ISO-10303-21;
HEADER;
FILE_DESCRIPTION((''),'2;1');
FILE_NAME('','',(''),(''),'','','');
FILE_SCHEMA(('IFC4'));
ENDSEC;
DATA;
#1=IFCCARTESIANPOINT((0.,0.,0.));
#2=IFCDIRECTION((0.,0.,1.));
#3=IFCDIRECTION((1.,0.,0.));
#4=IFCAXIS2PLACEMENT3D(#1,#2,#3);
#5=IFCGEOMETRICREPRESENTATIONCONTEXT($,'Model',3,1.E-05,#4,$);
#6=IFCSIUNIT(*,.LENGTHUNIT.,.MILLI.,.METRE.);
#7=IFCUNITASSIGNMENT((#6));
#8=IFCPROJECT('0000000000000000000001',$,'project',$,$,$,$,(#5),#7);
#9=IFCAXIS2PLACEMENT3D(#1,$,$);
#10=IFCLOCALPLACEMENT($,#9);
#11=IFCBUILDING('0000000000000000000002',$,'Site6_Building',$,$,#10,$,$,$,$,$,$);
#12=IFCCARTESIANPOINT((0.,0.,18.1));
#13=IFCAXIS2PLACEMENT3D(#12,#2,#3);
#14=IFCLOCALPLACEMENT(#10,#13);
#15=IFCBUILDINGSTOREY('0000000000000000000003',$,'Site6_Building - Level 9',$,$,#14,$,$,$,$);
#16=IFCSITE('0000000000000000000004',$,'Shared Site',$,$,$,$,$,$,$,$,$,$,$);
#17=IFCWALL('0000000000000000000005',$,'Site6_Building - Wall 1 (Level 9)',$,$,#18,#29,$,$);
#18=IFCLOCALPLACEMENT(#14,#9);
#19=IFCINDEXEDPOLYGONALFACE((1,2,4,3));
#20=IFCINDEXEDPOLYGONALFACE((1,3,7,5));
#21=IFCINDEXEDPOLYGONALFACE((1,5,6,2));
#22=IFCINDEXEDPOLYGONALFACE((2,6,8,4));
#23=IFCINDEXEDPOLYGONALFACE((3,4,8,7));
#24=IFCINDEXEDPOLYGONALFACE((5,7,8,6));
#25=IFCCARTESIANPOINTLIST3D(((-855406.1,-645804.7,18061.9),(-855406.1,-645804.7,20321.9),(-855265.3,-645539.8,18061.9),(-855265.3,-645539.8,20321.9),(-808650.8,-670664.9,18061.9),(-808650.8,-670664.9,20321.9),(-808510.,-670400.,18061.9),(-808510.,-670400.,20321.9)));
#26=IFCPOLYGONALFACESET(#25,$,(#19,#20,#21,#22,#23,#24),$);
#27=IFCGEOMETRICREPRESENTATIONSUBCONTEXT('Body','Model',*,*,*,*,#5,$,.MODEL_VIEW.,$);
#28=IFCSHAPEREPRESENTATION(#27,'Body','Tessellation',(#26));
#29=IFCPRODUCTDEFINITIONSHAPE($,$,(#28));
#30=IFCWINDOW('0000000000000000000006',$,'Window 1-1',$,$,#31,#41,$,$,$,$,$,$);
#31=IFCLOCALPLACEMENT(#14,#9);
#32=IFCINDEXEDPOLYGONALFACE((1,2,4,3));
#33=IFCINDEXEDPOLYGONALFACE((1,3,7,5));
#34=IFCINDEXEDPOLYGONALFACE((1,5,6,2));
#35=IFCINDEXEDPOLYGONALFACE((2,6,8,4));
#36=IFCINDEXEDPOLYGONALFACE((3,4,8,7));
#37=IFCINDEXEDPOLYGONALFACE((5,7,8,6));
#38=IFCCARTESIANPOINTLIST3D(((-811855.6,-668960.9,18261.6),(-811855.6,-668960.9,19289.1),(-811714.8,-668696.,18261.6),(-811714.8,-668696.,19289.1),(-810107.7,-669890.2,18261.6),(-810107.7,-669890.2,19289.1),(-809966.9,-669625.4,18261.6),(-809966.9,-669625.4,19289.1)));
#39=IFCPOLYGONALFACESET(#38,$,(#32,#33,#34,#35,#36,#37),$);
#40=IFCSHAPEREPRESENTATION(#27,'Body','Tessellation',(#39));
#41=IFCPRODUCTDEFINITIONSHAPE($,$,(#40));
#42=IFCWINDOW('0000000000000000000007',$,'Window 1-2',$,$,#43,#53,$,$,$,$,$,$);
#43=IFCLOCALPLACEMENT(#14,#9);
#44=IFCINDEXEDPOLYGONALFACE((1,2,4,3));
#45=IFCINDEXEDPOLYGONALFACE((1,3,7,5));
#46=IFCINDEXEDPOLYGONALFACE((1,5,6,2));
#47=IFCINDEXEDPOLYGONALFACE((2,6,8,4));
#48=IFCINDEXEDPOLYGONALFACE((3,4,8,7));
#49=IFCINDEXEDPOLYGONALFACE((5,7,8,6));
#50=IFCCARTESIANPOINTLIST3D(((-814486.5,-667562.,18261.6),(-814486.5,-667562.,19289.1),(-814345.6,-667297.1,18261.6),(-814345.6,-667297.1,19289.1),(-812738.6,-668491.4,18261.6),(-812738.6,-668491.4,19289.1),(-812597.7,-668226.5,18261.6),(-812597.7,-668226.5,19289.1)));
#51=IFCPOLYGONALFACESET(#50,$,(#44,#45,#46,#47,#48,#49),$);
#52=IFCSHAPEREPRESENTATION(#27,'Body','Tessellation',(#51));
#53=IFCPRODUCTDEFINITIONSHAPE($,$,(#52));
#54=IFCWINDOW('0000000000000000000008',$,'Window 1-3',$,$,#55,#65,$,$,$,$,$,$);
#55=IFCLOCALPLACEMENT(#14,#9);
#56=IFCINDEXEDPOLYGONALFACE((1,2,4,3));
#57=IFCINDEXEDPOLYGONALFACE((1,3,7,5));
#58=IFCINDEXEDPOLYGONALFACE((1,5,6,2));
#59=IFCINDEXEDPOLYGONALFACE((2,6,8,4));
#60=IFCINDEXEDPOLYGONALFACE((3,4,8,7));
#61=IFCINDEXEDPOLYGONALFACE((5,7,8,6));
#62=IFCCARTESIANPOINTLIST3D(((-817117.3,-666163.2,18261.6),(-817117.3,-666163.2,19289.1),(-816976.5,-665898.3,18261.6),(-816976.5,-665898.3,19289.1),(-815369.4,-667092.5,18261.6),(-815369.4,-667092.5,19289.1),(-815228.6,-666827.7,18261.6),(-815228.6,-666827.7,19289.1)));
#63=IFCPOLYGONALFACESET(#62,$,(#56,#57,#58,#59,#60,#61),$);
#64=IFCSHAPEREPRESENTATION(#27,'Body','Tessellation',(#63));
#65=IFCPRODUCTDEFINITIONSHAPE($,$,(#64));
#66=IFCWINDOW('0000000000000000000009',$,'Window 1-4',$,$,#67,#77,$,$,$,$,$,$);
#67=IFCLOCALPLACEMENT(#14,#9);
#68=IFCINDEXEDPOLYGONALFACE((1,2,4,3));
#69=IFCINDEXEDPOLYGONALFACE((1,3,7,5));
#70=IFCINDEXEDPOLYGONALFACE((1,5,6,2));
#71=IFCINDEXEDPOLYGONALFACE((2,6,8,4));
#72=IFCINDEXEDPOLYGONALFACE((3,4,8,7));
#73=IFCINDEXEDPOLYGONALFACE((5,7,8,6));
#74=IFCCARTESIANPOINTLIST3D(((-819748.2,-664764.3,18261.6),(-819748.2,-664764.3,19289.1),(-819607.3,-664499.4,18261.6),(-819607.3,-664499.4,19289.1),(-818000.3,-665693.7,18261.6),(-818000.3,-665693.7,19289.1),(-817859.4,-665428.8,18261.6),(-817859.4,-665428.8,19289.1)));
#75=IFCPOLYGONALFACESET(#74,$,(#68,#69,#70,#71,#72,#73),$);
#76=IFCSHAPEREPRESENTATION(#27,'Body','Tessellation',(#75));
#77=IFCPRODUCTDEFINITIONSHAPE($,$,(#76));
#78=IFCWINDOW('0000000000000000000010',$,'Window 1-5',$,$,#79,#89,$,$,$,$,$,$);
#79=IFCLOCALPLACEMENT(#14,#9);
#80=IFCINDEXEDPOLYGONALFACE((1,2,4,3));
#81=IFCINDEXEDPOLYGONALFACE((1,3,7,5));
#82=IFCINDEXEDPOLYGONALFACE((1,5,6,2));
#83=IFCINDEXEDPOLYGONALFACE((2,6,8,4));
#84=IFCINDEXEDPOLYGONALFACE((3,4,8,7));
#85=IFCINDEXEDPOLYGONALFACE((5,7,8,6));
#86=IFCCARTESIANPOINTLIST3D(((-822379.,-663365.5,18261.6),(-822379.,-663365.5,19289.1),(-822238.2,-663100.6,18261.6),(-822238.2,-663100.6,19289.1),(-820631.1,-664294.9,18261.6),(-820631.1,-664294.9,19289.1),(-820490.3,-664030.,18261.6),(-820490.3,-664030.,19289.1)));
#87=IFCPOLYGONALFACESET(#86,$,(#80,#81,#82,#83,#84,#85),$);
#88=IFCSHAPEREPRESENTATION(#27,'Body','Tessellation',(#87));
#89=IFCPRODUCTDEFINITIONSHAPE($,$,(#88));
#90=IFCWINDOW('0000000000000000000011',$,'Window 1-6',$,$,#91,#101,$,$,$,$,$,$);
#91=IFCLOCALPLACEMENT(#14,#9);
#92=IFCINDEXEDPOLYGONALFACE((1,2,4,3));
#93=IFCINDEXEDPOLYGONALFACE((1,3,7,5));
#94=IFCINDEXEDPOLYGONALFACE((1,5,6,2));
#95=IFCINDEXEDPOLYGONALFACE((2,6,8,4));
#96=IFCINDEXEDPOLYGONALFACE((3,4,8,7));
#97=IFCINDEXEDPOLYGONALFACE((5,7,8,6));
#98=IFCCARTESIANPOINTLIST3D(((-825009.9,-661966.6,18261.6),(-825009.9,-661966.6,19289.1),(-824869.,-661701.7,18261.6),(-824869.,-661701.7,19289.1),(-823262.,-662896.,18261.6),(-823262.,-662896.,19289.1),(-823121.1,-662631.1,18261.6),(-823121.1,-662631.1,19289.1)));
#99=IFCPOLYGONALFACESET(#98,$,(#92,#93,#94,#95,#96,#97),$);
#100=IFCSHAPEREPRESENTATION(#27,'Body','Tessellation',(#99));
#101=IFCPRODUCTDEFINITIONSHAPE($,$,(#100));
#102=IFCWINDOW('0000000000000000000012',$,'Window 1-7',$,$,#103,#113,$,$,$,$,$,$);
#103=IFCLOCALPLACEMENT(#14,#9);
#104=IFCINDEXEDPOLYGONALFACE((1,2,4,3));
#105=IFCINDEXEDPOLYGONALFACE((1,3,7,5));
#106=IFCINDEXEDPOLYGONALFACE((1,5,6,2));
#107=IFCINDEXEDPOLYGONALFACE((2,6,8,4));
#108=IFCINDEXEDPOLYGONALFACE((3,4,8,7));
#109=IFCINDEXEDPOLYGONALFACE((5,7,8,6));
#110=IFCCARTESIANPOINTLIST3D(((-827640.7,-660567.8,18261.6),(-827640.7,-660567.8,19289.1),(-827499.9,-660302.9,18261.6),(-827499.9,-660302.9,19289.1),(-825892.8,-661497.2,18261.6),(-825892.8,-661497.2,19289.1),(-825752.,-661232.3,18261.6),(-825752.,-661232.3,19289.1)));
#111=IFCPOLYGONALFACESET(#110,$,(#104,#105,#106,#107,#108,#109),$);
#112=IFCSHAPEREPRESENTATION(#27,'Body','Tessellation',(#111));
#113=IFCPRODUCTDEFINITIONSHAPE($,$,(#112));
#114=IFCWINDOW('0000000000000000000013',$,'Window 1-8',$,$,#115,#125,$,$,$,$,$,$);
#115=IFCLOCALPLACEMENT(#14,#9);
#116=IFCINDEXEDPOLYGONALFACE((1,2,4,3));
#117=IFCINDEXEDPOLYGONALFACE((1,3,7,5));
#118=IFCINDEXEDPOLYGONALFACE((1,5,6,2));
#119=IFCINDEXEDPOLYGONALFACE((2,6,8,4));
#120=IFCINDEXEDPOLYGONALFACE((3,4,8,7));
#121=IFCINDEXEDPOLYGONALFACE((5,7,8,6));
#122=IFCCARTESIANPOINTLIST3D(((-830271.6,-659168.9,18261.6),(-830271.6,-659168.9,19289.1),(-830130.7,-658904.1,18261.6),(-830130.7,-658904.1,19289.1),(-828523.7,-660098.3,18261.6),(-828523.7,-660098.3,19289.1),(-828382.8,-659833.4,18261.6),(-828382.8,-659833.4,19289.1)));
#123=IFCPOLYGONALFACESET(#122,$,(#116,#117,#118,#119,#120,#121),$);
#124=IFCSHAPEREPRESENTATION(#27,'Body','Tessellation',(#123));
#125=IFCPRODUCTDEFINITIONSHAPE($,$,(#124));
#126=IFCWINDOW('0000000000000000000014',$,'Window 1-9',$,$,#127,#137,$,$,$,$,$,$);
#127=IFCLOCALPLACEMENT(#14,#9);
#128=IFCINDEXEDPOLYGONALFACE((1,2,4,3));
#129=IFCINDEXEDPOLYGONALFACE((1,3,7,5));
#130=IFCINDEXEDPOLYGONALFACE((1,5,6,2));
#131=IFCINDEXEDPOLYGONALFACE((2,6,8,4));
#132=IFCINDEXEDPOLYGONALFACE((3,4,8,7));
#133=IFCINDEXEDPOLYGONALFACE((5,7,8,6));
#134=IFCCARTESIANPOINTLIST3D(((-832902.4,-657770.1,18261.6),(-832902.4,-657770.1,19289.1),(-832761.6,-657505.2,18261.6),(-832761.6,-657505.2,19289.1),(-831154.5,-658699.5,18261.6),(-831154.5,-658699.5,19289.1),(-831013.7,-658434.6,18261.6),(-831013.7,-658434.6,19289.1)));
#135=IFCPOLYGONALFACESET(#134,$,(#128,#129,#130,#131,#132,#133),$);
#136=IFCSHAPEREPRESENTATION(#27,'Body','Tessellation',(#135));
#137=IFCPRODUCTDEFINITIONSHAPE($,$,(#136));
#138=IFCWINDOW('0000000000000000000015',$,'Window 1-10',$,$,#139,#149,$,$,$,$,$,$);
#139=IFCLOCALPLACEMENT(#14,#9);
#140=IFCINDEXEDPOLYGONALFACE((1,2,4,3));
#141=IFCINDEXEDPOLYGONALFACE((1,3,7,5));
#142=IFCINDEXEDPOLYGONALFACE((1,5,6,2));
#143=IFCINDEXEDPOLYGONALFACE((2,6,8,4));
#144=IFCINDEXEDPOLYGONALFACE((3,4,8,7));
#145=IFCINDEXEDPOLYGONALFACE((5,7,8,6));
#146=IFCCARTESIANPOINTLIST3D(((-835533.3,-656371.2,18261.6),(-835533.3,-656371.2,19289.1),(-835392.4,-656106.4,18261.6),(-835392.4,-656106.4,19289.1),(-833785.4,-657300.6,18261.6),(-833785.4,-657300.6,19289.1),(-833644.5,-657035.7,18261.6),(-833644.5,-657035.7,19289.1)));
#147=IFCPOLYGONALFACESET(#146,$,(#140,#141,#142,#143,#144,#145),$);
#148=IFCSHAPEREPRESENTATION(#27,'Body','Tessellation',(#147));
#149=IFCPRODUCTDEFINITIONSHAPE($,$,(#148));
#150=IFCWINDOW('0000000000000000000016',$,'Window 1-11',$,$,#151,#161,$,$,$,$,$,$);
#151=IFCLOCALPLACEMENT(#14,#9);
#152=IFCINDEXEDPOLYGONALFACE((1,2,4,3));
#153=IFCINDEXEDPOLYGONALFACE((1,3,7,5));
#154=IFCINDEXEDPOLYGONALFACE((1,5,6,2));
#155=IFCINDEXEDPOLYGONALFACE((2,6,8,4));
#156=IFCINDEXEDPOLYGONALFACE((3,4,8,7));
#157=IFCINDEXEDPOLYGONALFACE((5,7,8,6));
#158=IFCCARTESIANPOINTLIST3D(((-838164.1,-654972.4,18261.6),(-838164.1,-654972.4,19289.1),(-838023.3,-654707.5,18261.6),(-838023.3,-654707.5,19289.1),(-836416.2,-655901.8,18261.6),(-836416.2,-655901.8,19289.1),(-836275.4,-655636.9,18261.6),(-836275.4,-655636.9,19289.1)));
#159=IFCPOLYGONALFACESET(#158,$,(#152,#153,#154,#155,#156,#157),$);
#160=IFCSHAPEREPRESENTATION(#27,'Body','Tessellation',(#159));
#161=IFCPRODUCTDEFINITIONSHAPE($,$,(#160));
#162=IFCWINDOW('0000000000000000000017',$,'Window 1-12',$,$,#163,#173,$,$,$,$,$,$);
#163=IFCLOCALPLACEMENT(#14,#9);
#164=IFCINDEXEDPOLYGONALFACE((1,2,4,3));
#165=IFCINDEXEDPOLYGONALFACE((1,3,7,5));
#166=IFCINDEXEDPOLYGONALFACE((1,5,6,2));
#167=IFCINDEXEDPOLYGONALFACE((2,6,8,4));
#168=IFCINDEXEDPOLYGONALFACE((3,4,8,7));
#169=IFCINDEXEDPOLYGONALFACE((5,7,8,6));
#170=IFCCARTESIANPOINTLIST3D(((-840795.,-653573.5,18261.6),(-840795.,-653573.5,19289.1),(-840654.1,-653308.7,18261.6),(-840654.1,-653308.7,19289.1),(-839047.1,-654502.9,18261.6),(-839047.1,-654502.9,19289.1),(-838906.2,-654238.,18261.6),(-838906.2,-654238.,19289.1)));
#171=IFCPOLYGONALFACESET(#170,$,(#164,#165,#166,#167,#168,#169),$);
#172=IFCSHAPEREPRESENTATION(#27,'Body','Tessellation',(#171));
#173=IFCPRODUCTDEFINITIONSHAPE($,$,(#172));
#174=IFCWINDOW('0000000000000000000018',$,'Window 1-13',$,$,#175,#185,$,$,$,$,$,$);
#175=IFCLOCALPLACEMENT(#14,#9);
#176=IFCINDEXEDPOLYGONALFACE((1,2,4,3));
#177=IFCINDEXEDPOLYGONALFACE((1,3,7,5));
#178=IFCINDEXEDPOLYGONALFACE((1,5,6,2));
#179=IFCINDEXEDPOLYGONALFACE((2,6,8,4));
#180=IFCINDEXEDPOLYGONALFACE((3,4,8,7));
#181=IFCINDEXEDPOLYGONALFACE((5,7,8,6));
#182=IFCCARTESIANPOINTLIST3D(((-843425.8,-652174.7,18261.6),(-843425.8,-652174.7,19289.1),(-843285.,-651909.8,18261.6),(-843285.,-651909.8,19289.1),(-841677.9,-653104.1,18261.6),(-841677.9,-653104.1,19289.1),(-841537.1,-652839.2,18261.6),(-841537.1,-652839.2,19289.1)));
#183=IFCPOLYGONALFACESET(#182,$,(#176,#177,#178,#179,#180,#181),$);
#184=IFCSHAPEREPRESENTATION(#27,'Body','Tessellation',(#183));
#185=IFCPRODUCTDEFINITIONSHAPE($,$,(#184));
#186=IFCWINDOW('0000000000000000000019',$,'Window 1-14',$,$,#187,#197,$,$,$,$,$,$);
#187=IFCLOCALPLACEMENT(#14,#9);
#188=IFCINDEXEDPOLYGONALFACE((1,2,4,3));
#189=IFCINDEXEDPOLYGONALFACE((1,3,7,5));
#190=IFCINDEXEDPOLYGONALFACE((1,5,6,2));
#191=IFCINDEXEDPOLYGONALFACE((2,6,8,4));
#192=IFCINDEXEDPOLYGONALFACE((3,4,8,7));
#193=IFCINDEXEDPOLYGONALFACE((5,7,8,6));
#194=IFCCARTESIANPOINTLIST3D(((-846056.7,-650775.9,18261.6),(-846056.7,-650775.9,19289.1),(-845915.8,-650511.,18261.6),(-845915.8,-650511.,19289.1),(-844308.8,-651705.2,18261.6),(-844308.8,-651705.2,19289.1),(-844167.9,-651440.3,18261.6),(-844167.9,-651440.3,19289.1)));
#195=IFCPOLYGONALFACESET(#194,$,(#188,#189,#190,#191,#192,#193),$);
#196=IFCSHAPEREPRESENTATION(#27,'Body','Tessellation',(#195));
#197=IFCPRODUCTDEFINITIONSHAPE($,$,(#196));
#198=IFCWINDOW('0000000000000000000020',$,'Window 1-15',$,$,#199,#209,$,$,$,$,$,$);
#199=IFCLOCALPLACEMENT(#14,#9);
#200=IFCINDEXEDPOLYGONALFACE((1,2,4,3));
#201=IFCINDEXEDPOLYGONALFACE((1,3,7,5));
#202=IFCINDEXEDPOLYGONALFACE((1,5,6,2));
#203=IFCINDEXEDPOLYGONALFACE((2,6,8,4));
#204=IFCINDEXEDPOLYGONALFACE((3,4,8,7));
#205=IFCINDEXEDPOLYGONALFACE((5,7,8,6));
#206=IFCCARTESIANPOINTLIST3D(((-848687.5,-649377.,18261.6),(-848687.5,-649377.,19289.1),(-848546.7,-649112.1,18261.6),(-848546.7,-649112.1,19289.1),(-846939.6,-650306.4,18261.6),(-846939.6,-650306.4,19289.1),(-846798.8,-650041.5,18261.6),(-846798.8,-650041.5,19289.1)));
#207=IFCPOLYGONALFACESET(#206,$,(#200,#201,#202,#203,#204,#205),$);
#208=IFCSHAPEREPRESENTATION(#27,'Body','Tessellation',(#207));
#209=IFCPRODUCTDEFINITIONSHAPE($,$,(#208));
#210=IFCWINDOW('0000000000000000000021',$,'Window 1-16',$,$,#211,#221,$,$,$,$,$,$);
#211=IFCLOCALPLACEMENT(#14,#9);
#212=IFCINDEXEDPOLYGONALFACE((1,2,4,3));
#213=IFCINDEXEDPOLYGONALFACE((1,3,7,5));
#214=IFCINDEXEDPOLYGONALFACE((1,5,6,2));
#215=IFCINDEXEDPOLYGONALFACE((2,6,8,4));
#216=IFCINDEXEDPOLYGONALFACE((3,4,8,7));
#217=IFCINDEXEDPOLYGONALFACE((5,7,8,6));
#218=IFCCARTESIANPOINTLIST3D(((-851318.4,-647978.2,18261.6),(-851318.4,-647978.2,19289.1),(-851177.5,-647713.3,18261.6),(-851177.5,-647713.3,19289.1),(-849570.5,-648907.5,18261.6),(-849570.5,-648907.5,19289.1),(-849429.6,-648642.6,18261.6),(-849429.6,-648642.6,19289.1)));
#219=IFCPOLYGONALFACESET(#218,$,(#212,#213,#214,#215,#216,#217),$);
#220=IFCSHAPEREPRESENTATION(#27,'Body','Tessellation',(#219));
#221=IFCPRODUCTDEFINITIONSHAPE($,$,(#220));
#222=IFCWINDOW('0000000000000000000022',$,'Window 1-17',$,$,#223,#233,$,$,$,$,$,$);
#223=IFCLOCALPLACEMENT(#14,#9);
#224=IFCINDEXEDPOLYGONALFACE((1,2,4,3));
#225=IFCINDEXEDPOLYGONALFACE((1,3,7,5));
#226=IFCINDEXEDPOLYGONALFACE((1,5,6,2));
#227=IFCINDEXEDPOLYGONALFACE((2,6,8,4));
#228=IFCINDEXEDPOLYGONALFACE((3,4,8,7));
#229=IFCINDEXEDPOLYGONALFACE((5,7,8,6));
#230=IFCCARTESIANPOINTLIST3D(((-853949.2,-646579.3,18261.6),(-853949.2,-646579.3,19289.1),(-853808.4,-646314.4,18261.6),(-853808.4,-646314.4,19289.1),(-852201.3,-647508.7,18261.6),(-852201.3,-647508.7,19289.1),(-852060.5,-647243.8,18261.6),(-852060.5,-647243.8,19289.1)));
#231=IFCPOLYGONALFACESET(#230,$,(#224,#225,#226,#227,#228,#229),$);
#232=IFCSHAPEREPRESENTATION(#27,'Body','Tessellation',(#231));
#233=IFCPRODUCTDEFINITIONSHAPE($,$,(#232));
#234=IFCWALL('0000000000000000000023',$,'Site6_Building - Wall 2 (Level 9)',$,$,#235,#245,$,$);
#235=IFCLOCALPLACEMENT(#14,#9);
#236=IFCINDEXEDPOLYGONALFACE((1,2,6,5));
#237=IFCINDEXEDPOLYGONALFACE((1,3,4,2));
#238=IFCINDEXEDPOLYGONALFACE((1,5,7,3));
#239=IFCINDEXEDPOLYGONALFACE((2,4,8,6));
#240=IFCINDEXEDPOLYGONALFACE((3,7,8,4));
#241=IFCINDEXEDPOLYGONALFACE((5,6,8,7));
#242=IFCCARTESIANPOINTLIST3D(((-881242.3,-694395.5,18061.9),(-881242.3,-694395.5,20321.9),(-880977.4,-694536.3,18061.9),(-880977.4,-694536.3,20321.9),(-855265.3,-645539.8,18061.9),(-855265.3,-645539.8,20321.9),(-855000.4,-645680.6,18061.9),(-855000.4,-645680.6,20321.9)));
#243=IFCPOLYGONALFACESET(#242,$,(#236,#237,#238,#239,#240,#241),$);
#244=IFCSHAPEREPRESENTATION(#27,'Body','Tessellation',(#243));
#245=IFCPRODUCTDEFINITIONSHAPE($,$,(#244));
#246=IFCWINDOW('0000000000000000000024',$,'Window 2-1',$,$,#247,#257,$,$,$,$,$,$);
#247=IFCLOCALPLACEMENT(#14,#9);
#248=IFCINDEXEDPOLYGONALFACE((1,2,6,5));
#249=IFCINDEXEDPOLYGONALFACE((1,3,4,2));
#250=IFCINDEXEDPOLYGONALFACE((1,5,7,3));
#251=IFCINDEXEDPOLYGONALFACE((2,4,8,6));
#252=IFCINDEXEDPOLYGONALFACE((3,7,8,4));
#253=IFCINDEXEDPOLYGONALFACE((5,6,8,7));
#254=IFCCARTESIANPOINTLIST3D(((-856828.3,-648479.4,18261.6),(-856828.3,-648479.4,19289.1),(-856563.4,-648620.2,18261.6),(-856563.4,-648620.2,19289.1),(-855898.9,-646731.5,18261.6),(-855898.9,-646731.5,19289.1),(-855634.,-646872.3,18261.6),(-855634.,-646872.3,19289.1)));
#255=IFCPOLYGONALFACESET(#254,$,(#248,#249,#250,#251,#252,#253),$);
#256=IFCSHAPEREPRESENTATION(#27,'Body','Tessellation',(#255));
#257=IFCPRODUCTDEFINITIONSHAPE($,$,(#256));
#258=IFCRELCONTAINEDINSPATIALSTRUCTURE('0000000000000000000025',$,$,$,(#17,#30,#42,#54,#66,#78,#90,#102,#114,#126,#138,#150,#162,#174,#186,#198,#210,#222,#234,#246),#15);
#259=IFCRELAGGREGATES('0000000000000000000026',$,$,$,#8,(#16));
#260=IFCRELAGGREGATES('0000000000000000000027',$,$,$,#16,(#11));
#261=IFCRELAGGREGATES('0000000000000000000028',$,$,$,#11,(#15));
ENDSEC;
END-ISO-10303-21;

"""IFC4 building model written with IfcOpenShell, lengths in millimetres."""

from ifc_helpers import new_model, si_unit, frame, origin, origin_with_axes, place, context, subcontext, project, spatial, indexed_curve, outline, extrude, element, save


model = new_model("IFC4")

# Units and contexts
model_context = context("Model", 3, precision=1e-05, world=origin_with_axes())
body_context = subcontext(model_context, "Body", "Model", "MODEL_VIEW")
ifc_project = project(units=[si_unit("LENGTHUNIT", "METRE", prefix="MILLI")], contexts=[model_context])

# Site, building, storey
site = spatial("IfcSite", under=ifc_project, Name="Shared Site")
building_placement = place(None, origin())
building = spatial("IfcBuilding", under=site, at=building_placement, Name="Site6_Building")
storey_placement = place(building_placement, frame((0.0, 0.0, 18.1), z_axis=(0.0, 0.0, 1.0), x_axis=(1.0, 0.0, 0.0)))
storey = spatial("IfcBuildingStorey", under=building, at=storey_placement, Name="Site6_Building - Level 9")

# Wall
wall_1_placement = place(storey_placement, frame((-808510.0, -670400.0, 18061.9), z_axis=(0.0, 0.0, 1.0), x_axis=(-0.882948, 0.469472, 0.0)))
element("IfcWall", 1, at=wall_1_placement, inside=storey, Name="Site6_Building - Wall 1 (Level 9)", context=body_context, shape_type="SweptSolid", body=[
    extrude(outline(indexed_curve([(0.0, 0.0), (0.0, 300.0), (52953.6, 300.0), (52953.6, 0.0), (0.0, 0.0)], self_intersect=False)), origin_with_axes(), (0.0, 0.0, 1.0), 2260.0),
])

# Windows
for number, where, z_axis, x_axis, name in (
    (2, (-809966.9, -669625.4, 18261.6), (0.0, 0.0, 1.0), (-0.882948, 0.469472, 0.0), "Window 1-1"),
    (3, (-812597.7, -668226.5, 18261.6), (0.0, 0.0, 1.0), (-0.882948, 0.469472, 0.0), "Window 1-2"),
    (4, (-815228.6, -666827.7, 18261.6), (0.0, 0.0, 1.0), (-0.882948, 0.469472, 0.0), "Window 1-3"),
    (5, (-817859.4, -665428.8, 18261.6), (0.0, 0.0, 1.0), (-0.882948, 0.469472, 0.0), "Window 1-4"),
    (6, (-820490.3, -664030.0, 18261.6), (0.0, 0.0, 1.0), (-0.882948, 0.469472, 0.0), "Window 1-5"),
    (7, (-823121.1, -662631.1, 18261.6), (0.0, 0.0, 1.0), (-0.882948, 0.469472, 0.0), "Window 1-6"),
    (8, (-825752.0, -661232.3, 18261.6), (0.0, 0.0, 1.0), (-0.882948, 0.469472, 0.0), "Window 1-7"),
    (9, (-828382.8, -659833.4, 18261.6), (0.0, 0.0, 1.0), (-0.882948, 0.469472, 0.0), "Window 1-8"),
    (10, (-831013.7, -658434.6, 18261.6), (0.0, 0.0, 1.0), (-0.882948, 0.469472, 0.0), "Window 1-9"),
    (11, (-833644.5, -657035.7, 18261.6), (0.0, 0.0, 1.0), (-0.882948, 0.469472, 0.0), "Window 1-10"),
    (12, (-836275.4, -655636.9, 18261.6), (0.0, 0.0, 1.0), (-0.882948, 0.469472, 0.0), "Window 1-11"),
    (13, (-838906.2, -654238.0, 18261.6), (0.0, 0.0, 1.0), (-0.882948, 0.469472, 0.0), "Window 1-12"),
    (14, (-841537.1, -652839.2, 18261.6), (0.0, 0.0, 1.0), (-0.882948, 0.469472, 0.0), "Window 1-13"),
    (15, (-844167.9, -651440.3, 18261.6), (0.0, 0.0, 1.0), (-0.882948, 0.469472, 0.0), "Window 1-14"),
    (16, (-846798.8, -650041.5, 18261.6), (0.0, 0.0, 1.0), (-0.882948, 0.469472, 0.0), "Window 1-15"),
    (17, (-849429.6, -648642.6, 18261.6), (0.0, 0.0, 1.0), (-0.882948, 0.469472, 0.0), "Window 1-16"),
    (18, (-852060.5, -647243.8, 18261.6), (0.0, 0.0, 1.0), (-0.882948, 0.469472, 0.0), "Window 1-17"),
):
    element("IfcWindow", number, at=place(storey_placement, frame(where, z_axis=z_axis, x_axis=x_axis)), inside=storey, Name=name, context=body_context, shape_type="SweptSolid", body=[
        extrude(outline(indexed_curve([(0.0, 0.0), (0.0, 300.0), (1979.6, 300.0), (1979.6, 0.0), (0.0, 0.0)], self_intersect=False)), origin_with_axes(), (0.0, 0.0, 1.0), 1027.5),
    ])

# Wall
wall_2_placement = place(storey_placement, frame((-855265.3, -645539.8, 18061.9), z_axis=(0.0, 0.0, 1.0), x_axis=(-0.469472, -0.882948, 0.0)))
element("IfcWall", 19, at=wall_2_placement, inside=storey, Name="Site6_Building - Wall 2 (Level 9)", context=body_context, shape_type="SweptSolid", body=[
    extrude(outline(indexed_curve([(0.0, 0.0), (0.0, 300.0), (55332.5, 300.0), (55332.5, 0.0), (0.0, 0.0)], self_intersect=False)), origin_with_axes(), (0.0, 0.0, 1.0), 2260.0),
])

# Window
for number, where, z_axis, x_axis, name in (
    (20, (-855898.9, -646731.5, 18261.6), (0.0, 0.0, 1.0), (-0.469472, -0.882948, 0.0), "Window 2-1"),
):
    element("IfcWindow", number, at=place(storey_placement, frame(where, z_axis=z_axis, x_axis=x_axis)), inside=storey, Name=name, context=body_context, shape_type="SweptSolid", body=[
        extrude(outline(indexed_curve([(0.0, 0.0), (0.0, 300.0), (1979.6, 300.0), (1979.6, 0.0), (0.0, 0.0)], self_intersect=False)), origin_with_axes(), (0.0, 0.0, 1.0), 1027.5),
    ])

save(model, "model.ifc")
